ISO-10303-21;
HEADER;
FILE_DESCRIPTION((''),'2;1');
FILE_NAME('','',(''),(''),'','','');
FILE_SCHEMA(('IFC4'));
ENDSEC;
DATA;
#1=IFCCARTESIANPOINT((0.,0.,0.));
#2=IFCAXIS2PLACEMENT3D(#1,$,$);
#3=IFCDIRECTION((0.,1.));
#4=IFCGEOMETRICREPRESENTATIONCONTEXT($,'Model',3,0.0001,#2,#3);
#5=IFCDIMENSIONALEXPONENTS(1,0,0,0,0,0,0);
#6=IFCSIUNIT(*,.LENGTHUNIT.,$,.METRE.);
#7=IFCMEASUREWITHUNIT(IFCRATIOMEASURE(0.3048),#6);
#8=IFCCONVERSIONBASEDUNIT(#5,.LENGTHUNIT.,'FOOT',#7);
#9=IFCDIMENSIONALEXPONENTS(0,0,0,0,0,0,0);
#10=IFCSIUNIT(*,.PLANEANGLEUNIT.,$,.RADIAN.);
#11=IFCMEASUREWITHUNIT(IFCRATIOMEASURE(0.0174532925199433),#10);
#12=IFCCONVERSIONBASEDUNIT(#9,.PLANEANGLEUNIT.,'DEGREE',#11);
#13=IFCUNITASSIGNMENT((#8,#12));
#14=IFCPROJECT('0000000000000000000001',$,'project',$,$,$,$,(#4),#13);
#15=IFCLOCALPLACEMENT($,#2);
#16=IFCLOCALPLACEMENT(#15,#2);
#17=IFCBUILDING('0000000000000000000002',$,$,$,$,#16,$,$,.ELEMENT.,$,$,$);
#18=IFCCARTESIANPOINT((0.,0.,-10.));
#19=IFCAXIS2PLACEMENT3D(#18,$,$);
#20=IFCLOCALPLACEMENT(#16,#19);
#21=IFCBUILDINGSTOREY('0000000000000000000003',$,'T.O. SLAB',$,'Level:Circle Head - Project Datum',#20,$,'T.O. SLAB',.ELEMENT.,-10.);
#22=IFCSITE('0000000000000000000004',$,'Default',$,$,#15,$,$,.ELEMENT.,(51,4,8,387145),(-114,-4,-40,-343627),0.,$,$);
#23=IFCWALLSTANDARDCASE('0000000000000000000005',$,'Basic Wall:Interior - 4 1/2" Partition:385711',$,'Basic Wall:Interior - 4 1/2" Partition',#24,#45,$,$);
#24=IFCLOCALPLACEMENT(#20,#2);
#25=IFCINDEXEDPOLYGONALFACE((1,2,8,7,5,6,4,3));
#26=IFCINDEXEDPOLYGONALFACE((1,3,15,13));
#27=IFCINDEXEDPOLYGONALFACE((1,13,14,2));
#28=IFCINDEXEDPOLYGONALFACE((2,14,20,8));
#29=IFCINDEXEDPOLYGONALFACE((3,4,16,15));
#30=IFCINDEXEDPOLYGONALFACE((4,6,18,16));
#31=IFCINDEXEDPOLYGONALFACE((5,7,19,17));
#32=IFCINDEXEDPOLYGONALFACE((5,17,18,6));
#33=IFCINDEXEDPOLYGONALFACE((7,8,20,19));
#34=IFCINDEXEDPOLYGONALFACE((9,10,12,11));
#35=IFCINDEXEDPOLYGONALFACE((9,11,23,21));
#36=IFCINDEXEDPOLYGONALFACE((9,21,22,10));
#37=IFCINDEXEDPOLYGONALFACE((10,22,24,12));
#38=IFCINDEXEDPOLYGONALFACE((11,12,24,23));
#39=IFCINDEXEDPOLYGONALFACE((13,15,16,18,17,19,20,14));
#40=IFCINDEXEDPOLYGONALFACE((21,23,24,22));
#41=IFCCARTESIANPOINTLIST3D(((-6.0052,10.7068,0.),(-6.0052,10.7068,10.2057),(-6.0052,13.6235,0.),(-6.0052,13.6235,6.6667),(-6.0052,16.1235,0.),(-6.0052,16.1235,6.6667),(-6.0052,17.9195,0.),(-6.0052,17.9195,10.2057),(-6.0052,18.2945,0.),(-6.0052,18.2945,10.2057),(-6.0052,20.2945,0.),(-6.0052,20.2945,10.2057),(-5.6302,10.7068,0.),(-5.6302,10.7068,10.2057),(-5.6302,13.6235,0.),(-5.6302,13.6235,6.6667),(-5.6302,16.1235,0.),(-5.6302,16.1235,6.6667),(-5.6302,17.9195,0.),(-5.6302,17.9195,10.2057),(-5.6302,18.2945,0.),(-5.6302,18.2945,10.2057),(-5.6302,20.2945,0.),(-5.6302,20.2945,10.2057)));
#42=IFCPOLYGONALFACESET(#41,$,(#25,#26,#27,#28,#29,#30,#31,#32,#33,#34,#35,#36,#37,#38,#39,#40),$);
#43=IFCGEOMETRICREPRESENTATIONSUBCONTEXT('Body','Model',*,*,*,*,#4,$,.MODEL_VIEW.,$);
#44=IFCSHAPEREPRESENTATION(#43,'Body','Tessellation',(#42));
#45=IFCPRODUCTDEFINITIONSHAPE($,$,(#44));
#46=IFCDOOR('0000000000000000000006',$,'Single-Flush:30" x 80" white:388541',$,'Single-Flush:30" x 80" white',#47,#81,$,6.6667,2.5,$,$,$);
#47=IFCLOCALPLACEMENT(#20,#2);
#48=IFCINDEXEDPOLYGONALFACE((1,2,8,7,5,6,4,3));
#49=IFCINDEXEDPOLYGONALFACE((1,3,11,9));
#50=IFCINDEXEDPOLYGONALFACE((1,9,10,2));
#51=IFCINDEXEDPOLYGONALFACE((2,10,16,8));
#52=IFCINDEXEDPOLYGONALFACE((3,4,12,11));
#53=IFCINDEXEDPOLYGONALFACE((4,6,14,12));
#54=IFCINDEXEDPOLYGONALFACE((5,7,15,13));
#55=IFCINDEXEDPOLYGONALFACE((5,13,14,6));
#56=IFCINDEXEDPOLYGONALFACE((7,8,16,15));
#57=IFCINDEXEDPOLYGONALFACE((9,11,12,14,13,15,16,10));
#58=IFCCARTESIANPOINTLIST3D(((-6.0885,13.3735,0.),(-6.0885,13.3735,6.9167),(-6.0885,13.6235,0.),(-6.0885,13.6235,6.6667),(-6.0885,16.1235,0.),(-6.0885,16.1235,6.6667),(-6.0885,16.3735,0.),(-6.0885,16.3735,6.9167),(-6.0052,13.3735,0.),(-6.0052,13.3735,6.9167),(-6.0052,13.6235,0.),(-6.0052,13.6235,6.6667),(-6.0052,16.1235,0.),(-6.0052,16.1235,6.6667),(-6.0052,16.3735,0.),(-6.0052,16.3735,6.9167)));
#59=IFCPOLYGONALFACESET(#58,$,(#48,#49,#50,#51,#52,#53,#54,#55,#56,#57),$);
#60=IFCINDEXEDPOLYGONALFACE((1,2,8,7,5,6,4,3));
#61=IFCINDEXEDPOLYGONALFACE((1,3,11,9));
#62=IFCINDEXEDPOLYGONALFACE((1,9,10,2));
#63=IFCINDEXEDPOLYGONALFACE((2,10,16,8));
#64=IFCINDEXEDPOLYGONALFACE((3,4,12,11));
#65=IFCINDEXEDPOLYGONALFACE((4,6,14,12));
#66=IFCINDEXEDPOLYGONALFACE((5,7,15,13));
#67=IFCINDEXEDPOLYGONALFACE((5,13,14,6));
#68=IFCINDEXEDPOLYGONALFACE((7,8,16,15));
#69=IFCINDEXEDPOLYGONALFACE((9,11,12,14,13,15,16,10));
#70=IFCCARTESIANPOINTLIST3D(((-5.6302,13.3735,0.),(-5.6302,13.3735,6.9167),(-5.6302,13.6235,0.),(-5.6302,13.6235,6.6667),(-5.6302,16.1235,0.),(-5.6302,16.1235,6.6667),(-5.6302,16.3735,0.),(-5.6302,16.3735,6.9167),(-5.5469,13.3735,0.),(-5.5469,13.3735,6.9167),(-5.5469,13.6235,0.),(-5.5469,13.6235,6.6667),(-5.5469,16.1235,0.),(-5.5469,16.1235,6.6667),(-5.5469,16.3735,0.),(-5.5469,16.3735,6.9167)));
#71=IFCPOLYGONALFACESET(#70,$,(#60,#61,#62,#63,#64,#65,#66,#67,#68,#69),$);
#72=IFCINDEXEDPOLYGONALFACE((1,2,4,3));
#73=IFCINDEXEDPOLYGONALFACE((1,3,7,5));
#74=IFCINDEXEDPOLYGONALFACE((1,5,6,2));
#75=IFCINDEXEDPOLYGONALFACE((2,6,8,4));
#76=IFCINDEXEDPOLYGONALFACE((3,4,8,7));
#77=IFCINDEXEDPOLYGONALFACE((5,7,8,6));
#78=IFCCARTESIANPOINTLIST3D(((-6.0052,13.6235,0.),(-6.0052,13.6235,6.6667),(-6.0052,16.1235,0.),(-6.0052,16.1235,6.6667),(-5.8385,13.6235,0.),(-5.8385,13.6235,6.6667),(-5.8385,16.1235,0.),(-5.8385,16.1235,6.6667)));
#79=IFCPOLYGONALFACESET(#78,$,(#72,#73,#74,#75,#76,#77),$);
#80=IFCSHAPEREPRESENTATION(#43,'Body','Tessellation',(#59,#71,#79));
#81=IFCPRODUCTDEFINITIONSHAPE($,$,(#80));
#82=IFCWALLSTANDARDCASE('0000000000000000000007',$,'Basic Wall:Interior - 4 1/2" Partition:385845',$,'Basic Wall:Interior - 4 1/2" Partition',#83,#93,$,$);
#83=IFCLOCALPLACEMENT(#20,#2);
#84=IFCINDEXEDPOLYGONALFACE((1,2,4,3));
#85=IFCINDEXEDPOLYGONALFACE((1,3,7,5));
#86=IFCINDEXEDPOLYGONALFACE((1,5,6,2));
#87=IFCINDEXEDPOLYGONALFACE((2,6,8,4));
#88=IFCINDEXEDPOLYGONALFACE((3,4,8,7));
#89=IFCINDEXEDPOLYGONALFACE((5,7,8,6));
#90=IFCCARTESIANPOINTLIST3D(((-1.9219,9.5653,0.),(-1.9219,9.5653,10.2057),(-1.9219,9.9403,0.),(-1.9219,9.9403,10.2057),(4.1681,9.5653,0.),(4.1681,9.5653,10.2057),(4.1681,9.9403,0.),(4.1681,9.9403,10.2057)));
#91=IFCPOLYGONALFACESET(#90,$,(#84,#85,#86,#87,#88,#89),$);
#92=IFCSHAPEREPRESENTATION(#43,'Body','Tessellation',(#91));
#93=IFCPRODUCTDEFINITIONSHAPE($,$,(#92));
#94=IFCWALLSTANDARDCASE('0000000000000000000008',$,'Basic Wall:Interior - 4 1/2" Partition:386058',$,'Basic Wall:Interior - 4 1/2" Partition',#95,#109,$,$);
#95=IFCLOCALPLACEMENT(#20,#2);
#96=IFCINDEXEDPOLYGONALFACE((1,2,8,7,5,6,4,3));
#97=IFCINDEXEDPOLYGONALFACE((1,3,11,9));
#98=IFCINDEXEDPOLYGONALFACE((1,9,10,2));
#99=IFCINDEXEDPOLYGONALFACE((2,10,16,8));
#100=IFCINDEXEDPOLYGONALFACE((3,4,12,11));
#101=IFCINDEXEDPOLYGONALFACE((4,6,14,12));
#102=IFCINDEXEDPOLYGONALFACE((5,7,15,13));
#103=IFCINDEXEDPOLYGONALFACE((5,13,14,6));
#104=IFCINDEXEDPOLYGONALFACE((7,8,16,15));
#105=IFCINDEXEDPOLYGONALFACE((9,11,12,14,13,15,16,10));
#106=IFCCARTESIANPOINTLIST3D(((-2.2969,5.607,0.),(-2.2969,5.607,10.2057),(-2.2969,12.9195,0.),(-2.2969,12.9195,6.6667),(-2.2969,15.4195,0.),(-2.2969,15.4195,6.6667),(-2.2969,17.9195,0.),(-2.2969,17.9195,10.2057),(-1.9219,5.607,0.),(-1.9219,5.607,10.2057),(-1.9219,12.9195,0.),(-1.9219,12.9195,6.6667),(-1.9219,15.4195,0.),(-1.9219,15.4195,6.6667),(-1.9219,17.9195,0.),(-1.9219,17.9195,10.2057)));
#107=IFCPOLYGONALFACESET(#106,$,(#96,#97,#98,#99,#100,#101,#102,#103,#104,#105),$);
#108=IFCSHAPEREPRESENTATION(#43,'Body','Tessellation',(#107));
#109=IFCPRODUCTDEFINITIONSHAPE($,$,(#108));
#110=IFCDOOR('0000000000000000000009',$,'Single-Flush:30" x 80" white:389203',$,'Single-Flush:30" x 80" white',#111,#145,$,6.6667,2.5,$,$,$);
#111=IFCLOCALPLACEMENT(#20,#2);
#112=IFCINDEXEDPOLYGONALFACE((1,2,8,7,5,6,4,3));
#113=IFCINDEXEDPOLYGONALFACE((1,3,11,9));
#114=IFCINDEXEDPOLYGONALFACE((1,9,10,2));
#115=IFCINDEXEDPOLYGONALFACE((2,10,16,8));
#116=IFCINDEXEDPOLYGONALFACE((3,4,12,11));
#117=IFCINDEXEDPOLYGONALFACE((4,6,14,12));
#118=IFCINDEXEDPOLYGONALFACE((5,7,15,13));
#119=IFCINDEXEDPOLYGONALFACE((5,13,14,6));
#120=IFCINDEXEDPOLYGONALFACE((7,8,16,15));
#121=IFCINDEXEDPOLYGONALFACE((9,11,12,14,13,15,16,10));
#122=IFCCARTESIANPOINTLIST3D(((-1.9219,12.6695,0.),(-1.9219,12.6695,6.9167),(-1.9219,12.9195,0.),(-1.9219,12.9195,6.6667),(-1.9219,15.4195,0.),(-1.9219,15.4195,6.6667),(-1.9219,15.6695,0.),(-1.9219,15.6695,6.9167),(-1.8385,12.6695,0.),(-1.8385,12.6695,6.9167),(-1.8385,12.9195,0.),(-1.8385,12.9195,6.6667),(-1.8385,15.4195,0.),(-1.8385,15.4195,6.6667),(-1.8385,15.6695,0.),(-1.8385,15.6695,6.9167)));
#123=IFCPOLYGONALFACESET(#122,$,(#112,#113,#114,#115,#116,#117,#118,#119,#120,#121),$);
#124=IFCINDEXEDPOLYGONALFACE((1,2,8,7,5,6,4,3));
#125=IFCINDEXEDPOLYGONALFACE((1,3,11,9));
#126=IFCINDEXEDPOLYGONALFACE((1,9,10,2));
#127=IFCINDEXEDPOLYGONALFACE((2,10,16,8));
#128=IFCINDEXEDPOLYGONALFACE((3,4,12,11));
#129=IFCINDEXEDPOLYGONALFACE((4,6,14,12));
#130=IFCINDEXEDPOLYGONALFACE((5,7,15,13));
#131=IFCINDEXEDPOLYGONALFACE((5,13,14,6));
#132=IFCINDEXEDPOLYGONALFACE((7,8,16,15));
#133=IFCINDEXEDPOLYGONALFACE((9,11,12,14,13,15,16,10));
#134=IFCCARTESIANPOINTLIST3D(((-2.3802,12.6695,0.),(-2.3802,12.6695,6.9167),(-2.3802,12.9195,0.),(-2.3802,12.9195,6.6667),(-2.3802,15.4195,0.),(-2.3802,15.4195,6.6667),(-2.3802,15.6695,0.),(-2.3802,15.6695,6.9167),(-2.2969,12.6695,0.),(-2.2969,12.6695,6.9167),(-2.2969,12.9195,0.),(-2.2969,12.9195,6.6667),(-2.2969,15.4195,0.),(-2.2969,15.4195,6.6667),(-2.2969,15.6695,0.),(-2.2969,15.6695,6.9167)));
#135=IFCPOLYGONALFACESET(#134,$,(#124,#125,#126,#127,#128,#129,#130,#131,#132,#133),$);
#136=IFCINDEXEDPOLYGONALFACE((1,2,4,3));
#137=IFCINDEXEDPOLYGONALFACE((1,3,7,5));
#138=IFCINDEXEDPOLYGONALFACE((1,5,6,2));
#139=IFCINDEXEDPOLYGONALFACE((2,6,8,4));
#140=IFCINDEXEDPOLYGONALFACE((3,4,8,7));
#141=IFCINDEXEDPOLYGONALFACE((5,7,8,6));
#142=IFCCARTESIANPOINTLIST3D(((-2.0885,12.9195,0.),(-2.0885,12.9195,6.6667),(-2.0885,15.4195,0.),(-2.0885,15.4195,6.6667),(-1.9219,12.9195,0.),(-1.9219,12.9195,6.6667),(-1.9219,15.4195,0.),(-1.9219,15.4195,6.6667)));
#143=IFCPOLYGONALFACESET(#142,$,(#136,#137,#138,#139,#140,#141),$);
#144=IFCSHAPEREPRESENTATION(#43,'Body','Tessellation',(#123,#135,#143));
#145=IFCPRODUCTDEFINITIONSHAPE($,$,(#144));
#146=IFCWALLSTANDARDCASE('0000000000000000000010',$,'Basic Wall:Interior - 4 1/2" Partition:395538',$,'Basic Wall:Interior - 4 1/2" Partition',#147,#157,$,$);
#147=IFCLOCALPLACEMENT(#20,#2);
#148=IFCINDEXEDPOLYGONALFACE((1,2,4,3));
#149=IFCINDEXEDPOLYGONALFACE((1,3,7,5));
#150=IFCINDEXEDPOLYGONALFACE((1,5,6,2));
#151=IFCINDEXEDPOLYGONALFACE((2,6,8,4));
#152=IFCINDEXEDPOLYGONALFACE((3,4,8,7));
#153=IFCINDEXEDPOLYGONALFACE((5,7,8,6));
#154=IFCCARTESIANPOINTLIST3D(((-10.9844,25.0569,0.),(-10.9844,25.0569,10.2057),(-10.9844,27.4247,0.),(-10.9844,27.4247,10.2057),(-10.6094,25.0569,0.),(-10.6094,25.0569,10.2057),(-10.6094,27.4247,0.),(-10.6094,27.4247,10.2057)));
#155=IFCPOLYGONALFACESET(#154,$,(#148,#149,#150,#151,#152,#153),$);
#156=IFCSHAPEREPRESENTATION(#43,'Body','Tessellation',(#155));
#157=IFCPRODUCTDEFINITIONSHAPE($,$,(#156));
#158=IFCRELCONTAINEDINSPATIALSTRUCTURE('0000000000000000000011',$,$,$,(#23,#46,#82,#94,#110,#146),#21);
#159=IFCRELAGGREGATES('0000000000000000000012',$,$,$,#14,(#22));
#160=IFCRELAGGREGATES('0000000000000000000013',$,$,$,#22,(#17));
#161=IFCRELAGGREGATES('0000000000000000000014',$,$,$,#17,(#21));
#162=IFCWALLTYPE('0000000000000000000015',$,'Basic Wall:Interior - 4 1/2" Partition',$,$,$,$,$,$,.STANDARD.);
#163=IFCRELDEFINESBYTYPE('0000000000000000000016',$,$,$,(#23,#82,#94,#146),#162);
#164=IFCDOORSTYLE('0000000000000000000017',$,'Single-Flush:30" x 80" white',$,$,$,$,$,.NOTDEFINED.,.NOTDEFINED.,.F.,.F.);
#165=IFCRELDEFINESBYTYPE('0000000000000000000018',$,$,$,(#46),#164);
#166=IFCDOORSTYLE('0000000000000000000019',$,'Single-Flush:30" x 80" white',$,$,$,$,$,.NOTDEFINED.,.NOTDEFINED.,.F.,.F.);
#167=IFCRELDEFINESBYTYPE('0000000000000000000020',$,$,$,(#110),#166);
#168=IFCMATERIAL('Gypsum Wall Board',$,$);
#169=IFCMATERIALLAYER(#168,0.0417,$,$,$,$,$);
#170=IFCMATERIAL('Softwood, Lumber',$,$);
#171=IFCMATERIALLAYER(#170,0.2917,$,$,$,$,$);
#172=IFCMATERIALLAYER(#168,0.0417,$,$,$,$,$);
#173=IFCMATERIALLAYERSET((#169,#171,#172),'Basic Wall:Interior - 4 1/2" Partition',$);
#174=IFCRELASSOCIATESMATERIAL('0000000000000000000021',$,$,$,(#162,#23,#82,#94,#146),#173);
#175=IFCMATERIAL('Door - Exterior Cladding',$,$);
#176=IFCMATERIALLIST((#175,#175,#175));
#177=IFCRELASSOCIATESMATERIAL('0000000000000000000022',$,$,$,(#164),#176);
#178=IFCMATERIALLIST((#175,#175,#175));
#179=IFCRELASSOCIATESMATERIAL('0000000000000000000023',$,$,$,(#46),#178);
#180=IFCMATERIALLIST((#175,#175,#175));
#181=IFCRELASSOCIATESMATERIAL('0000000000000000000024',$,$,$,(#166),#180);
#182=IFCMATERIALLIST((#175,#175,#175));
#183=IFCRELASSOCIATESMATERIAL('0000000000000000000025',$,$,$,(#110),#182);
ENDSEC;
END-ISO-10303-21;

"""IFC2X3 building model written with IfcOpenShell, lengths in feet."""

from ifc_helpers import new_model, entity, si_unit, converted_unit, direction, frame, frame_2d, origin, origin_2d_with_axis, place, context, subcontext, project, spatial, polyline, rectangle, outline, extrude, source, transform, mapped, material, material_list, layer, layer_set, layer_usage, type_object, type_shapes, element, fill, save


model = new_model("IFC2X3")

# Units and contexts
model_context = context("Model", 3, precision=0.0001, world=origin(), true_north=direction((0.0, 1.0)))
body_context = subcontext(model_context, "Body", "Model", "MODEL_VIEW")
ifc_project = project(units=[converted_unit("LENGTHUNIT", "FOOT", entity("IfcRatioMeasure", 0.3048), si_unit("LENGTHUNIT", "METRE"), dimensions=[1, 0, 0, 0, 0, 0, 0]), converted_unit("PLANEANGLEUNIT", "DEGREE", entity("IfcRatioMeasure", 0.0174532925199433), si_unit("PLANEANGLEUNIT", "RADIAN"), dimensions=[0, 0, 0, 0, 0, 0, 0])], contexts=[model_context])

# Site, building, storey
site_placement = place(None, origin())
site = spatial("IfcSite", under=ifc_project, at=site_placement, Name="Default", CompositionType="ELEMENT", RefLatitude=(51, 4, 8, 387145), RefLongitude=(-114, -4, -40, -343627), RefElevation=0.0)
building_placement = place(site_placement, origin())
building = spatial("IfcBuilding", under=site, at=building_placement, CompositionType="ELEMENT")
storey_placement = place(building_placement, frame((0.0, 0.0, -10.0)))
storey = spatial("IfcBuildingStorey", under=building, at=storey_placement, Name="T.O. SLAB", ObjectType="Level:Circle Head - Project Datum", LongName="T.O. SLAB", CompositionType="ELEMENT", Elevation=-10.0)

# Shared definitions
ifc_material_1 = material(Name="Gypsum Wall Board")
ifc_layer_1 = layer(ifc_material_1, 0.0417)
ifc_material_2 = material(Name="Softwood, Lumber")
ifc_layer_2 = layer(ifc_material_2, 0.2917)
ifc_layer_3 = layer(ifc_material_1, 0.0417)
ifc_layer_set_1 = layer_set([ifc_layer_1, ifc_layer_2, ifc_layer_3], Name="Basic Wall:Interior - 4 1/2\" Partition")
wall_type_1 = type_object("IfcWallType", Name="Basic Wall:Interior - 4 1/2\" Partition", PredefinedType="STANDARD", material=ifc_layer_set_1)

# Shared definitions
ifc_material_3 = material(Name="Door - Exterior Cladding")

# Wall, openings, door
ifc_layer_usage_1 = layer_usage(ifc_layer_set_1, "AXIS2", "NEGATIVE", 0.1875)
wall_1_placement = place(storey_placement, frame((-5.8177, 20.2945, 0.0), z_axis=(0.0, 0.0, 1.0), x_axis=(0.0, -1.0, 0.0)))
wall_1 = element("IfcWallStandardCase", 1, at=wall_1_placement, inside=storey, type_object=wall_type_1, material=ifc_layer_usage_1, Name="Basic Wall:Interior - 4 1/2\" Partition:385711", ObjectType="Basic Wall:Interior - 4 1/2\" Partition", context=body_context, shape_type="SweptSolid", body=[
    extrude(rectangle(XDim=9.5877, YDim=0.375, at=frame_2d((4.7938, 0.0), x_axis=(-1.0, 0.0))), origin(), (0.0, 0.0, 1.0), 10.2057),
])
opening_1_placement = place(storey_placement, frame((-5.8177, 20.2945, 0.0), z_axis=(0.0, 0.0, 1.0), x_axis=(0.0, -1.0, 0.0)))
element("IfcOpeningElement", 2, at=opening_1_placement, cuts=wall_1, ObjectType="Opening", context=body_context, shape_type="SweptSolid", body=[
    extrude(rectangle(XDim=10.2057, YDim=0.375, at=origin_2d_with_axis()), frame((2.375, 0.0, 5.1029), z_axis=(-1.0, 0.0, 0.0), x_axis=(0.0, 0.0, 1.0)), (0.0, 0.0, 1.0), 0.375),
])
opening_2_placement = place(wall_1_placement, frame((6.671, 0.1875, 0.0)))
opening_2 = element("IfcOpeningElement", 3, at=opening_2_placement, cuts=wall_1, ObjectType="Opening", context=body_context, shape_type="SweptSolid", body=[
    extrude(rectangle(XDim=2.5, YDim=6.6667, at=frame_2d((3.3333, 1.25), x_axis=(0.0, 1.0))), frame((0.0, 0.0, 0.0), z_axis=(0.0, -1.0, 0.0), x_axis=(0.0, 0.0, 1.0)), (0.0, 0.0, 1.0), 0.375),
])
ifc_material_list_1 = material_list([ifc_material_3, ifc_material_3, ifc_material_3])
ifc_material_list_2 = material_list([ifc_material_3, ifc_material_3, ifc_material_3])
door_style_1 = type_object("IfcDoorStyle", Name="Single-Flush:30\" x 80\" white", ConstructionType="NOTDEFINED", OperationType="NOTDEFINED", ParameterTakesPrecedence=False, Sizeable=False, material=ifc_material_list_2)
shared_shape_1 = source(origin(), body_context, "Body", "SweptSolid", [
    extrude(outline(polyline([(-1.5, -3.5208), (1.5, -3.5208), (1.5, 3.3958), (1.25, 3.3958), (1.25, -3.2708), (-1.25, -3.2708), (-1.25, 3.3958), (-1.5, 3.3958), (-1.5, -3.5208)])), frame((1.25, 0.375, 3.3958), z_axis=(0.0, 1.0, 0.0), x_axis=(1.0, 0.0, 0.0)), (0.0, 0.0, 1.0), 0.0833),
    extrude(outline(polyline([(-3.5208, -1.5), (3.3958, -1.5), (3.3958, -1.25), (-3.2708, -1.25), (-3.2708, 1.25), (3.3958, 1.25), (3.3958, 1.5), (-3.5208, 1.5), (-3.5208, -1.5)])), frame((1.25, -0.0833, 3.3958), z_axis=(0.0, 1.0, 0.0), x_axis=(0.0, 0.0, -1.0)), (0.0, 0.0, 1.0), 0.0833),
    extrude(rectangle(XDim=0.1667, YDim=2.5, at=frame_2d((0.0, 0.0), x_axis=(1.0, 0.0))), frame((1.25, 0.2917, 0.0), z_axis=(0.0, 0.0, 1.0), x_axis=(0.0, 1.0, 0.0)), (0.0, 0.0, 1.0), 6.6667),
])
type_shapes(door_style_1, [shared_shape_1])
door_1_placement = place(opening_2_placement, frame((0.0, 0.0, 0.0), z_axis=(0.0, 0.0, 1.0), x_axis=(-1.0, 0.0, 0.0)))
door_1 = element("IfcDoor", 4, at=door_1_placement, inside=storey, type_object=door_style_1, material=ifc_material_list_1, Name="Single-Flush:30\" x 80\" white:388541", ObjectType="Single-Flush:30\" x 80\" white", OverallHeight=6.6667, OverallWidth=2.5, context=body_context, shape_type="MappedRepresentation", body=[
    mapped(shared_shape_1, transform((0.0, 0.0, 0.0), scale=1.0)),
])
fill(opening_2, door_1)

# Wall
ifc_layer_usage_2 = layer_usage(ifc_layer_set_1, "AXIS2", "NEGATIVE", 0.1875)
wall_2_placement = place(storey_placement, frame((-1.9219, 9.7528, 0.0)))
element("IfcWallStandardCase", 5, at=wall_2_placement, inside=storey, type_object=wall_type_1, material=ifc_layer_usage_2, Name="Basic Wall:Interior - 4 1/2\" Partition:385845", ObjectType="Basic Wall:Interior - 4 1/2\" Partition", context=body_context, shape_type="SweptSolid", body=[
    extrude(rectangle(XDim=6.09, YDim=0.375, at=frame_2d((3.045, 0.0), x_axis=(-1.0, 0.0))), origin(), (0.0, 0.0, 1.0), 10.2057),
])

# Wall, opening, door
ifc_layer_usage_3 = layer_usage(ifc_layer_set_1, "AXIS2", "NEGATIVE", 0.1875)
wall_3_placement = place(storey_placement, frame((-2.1094, 17.9195, 0.0), z_axis=(0.0, 0.0, 1.0), x_axis=(0.0, -1.0, 0.0)))
wall_3 = element("IfcWallStandardCase", 6, at=wall_3_placement, inside=storey, type_object=wall_type_1, material=ifc_layer_usage_3, Name="Basic Wall:Interior - 4 1/2\" Partition:386058", ObjectType="Basic Wall:Interior - 4 1/2\" Partition", context=body_context, shape_type="SweptSolid", body=[
    extrude(rectangle(XDim=12.3125, YDim=0.375, at=frame_2d((6.1562, 0.0), x_axis=(-1.0, 0.0))), origin(), (0.0, 0.0, 1.0), 10.2057),
])
opening_3_placement = place(wall_3_placement, frame((2.5, -0.1875, 0.0)))
opening_3 = element("IfcOpeningElement", 7, at=opening_3_placement, cuts=wall_3, ObjectType="Opening", context=body_context, shape_type="SweptSolid", body=[
    extrude(rectangle(XDim=2.5, YDim=6.6667, at=frame_2d((3.3333, 1.25), x_axis=(0.0, -1.0))), frame((0.0, 0.0, 0.0), z_axis=(0.0, 1.0, 0.0), x_axis=(0.0, 0.0, 1.0)), (0.0, 0.0, 1.0), 0.375),
])
ifc_material_list_3 = material_list([ifc_material_3, ifc_material_3, ifc_material_3])
ifc_material_list_4 = material_list([ifc_material_3, ifc_material_3, ifc_material_3])
door_style_2 = type_object("IfcDoorStyle", Name="Single-Flush:30\" x 80\" white", ConstructionType="NOTDEFINED", OperationType="NOTDEFINED", ParameterTakesPrecedence=False, Sizeable=False, material=ifc_material_list_4)
shared_shape_2 = source(origin(), body_context, "Body", "SweptSolid", [
    extrude(outline(polyline([(-1.5, -3.5208), (1.5, -3.5208), (1.5, 3.3958), (1.25, 3.3958), (1.25, -3.2708), (-1.25, -3.2708), (-1.25, 3.3958), (-1.5, 3.3958), (-1.5, -3.5208)])), frame((1.25, 0.4583, 3.3958), z_axis=(0.0, -1.0, 0.0), x_axis=(-1.0, 0.0, 0.0)), (0.0, 0.0, 1.0), 0.0833),
    extrude(outline(polyline([(-3.5208, -1.5), (3.3958, -1.5), (3.3958, -1.25), (-3.2708, -1.25), (-3.2708, 1.25), (3.3958, 1.25), (3.3958, 1.5), (-3.5208, 1.5), (-3.5208, -1.5)])), frame((1.25, 0.0, 3.3958), z_axis=(0.0, -1.0, 0.0), x_axis=(0.0, 0.0, -1.0)), (0.0, 0.0, 1.0), 0.0833),
    extrude(rectangle(XDim=2.5, YDim=0.1667, at=origin_2d_with_axis()), frame((1.25, 0.2917, 0.0)), (0.0, 0.0, 1.0), 6.6667),
])
type_shapes(door_style_2, [shared_shape_2])
door_2_placement = place(opening_3_placement, origin())
door_2 = element("IfcDoor", 8, at=door_2_placement, inside=storey, type_object=door_style_2, material=ifc_material_list_3, Name="Single-Flush:30\" x 80\" white:389203", ObjectType="Single-Flush:30\" x 80\" white", OverallHeight=6.6667, OverallWidth=2.5, context=body_context, shape_type="MappedRepresentation", body=[
    mapped(shared_shape_2, transform((0.0, 0.0, 0.0), scale=1.0)),
])
fill(opening_3, door_2)

# Wall
ifc_layer_usage_4 = layer_usage(ifc_layer_set_1, "AXIS2", "NEGATIVE", 0.1875)
wall_4_placement = place(storey_placement, frame((-10.7969, 25.0569, 0.0), z_axis=(0.0, 0.0, 1.0), x_axis=(0.0, 1.0, 0.0)))
element("IfcWallStandardCase", 9, at=wall_4_placement, inside=storey, type_object=wall_type_1, material=ifc_layer_usage_4, Name="Basic Wall:Interior - 4 1/2\" Partition:395538", ObjectType="Basic Wall:Interior - 4 1/2\" Partition", context=body_context, shape_type="SweptSolid", body=[
    extrude(rectangle(XDim=2.3678, YDim=0.375, at=frame_2d((1.1839, 0.0), x_axis=(-1.0, 0.0))), origin(), (0.0, 0.0, 1.0), 10.2057),
])

save(model, "model.ifc")
